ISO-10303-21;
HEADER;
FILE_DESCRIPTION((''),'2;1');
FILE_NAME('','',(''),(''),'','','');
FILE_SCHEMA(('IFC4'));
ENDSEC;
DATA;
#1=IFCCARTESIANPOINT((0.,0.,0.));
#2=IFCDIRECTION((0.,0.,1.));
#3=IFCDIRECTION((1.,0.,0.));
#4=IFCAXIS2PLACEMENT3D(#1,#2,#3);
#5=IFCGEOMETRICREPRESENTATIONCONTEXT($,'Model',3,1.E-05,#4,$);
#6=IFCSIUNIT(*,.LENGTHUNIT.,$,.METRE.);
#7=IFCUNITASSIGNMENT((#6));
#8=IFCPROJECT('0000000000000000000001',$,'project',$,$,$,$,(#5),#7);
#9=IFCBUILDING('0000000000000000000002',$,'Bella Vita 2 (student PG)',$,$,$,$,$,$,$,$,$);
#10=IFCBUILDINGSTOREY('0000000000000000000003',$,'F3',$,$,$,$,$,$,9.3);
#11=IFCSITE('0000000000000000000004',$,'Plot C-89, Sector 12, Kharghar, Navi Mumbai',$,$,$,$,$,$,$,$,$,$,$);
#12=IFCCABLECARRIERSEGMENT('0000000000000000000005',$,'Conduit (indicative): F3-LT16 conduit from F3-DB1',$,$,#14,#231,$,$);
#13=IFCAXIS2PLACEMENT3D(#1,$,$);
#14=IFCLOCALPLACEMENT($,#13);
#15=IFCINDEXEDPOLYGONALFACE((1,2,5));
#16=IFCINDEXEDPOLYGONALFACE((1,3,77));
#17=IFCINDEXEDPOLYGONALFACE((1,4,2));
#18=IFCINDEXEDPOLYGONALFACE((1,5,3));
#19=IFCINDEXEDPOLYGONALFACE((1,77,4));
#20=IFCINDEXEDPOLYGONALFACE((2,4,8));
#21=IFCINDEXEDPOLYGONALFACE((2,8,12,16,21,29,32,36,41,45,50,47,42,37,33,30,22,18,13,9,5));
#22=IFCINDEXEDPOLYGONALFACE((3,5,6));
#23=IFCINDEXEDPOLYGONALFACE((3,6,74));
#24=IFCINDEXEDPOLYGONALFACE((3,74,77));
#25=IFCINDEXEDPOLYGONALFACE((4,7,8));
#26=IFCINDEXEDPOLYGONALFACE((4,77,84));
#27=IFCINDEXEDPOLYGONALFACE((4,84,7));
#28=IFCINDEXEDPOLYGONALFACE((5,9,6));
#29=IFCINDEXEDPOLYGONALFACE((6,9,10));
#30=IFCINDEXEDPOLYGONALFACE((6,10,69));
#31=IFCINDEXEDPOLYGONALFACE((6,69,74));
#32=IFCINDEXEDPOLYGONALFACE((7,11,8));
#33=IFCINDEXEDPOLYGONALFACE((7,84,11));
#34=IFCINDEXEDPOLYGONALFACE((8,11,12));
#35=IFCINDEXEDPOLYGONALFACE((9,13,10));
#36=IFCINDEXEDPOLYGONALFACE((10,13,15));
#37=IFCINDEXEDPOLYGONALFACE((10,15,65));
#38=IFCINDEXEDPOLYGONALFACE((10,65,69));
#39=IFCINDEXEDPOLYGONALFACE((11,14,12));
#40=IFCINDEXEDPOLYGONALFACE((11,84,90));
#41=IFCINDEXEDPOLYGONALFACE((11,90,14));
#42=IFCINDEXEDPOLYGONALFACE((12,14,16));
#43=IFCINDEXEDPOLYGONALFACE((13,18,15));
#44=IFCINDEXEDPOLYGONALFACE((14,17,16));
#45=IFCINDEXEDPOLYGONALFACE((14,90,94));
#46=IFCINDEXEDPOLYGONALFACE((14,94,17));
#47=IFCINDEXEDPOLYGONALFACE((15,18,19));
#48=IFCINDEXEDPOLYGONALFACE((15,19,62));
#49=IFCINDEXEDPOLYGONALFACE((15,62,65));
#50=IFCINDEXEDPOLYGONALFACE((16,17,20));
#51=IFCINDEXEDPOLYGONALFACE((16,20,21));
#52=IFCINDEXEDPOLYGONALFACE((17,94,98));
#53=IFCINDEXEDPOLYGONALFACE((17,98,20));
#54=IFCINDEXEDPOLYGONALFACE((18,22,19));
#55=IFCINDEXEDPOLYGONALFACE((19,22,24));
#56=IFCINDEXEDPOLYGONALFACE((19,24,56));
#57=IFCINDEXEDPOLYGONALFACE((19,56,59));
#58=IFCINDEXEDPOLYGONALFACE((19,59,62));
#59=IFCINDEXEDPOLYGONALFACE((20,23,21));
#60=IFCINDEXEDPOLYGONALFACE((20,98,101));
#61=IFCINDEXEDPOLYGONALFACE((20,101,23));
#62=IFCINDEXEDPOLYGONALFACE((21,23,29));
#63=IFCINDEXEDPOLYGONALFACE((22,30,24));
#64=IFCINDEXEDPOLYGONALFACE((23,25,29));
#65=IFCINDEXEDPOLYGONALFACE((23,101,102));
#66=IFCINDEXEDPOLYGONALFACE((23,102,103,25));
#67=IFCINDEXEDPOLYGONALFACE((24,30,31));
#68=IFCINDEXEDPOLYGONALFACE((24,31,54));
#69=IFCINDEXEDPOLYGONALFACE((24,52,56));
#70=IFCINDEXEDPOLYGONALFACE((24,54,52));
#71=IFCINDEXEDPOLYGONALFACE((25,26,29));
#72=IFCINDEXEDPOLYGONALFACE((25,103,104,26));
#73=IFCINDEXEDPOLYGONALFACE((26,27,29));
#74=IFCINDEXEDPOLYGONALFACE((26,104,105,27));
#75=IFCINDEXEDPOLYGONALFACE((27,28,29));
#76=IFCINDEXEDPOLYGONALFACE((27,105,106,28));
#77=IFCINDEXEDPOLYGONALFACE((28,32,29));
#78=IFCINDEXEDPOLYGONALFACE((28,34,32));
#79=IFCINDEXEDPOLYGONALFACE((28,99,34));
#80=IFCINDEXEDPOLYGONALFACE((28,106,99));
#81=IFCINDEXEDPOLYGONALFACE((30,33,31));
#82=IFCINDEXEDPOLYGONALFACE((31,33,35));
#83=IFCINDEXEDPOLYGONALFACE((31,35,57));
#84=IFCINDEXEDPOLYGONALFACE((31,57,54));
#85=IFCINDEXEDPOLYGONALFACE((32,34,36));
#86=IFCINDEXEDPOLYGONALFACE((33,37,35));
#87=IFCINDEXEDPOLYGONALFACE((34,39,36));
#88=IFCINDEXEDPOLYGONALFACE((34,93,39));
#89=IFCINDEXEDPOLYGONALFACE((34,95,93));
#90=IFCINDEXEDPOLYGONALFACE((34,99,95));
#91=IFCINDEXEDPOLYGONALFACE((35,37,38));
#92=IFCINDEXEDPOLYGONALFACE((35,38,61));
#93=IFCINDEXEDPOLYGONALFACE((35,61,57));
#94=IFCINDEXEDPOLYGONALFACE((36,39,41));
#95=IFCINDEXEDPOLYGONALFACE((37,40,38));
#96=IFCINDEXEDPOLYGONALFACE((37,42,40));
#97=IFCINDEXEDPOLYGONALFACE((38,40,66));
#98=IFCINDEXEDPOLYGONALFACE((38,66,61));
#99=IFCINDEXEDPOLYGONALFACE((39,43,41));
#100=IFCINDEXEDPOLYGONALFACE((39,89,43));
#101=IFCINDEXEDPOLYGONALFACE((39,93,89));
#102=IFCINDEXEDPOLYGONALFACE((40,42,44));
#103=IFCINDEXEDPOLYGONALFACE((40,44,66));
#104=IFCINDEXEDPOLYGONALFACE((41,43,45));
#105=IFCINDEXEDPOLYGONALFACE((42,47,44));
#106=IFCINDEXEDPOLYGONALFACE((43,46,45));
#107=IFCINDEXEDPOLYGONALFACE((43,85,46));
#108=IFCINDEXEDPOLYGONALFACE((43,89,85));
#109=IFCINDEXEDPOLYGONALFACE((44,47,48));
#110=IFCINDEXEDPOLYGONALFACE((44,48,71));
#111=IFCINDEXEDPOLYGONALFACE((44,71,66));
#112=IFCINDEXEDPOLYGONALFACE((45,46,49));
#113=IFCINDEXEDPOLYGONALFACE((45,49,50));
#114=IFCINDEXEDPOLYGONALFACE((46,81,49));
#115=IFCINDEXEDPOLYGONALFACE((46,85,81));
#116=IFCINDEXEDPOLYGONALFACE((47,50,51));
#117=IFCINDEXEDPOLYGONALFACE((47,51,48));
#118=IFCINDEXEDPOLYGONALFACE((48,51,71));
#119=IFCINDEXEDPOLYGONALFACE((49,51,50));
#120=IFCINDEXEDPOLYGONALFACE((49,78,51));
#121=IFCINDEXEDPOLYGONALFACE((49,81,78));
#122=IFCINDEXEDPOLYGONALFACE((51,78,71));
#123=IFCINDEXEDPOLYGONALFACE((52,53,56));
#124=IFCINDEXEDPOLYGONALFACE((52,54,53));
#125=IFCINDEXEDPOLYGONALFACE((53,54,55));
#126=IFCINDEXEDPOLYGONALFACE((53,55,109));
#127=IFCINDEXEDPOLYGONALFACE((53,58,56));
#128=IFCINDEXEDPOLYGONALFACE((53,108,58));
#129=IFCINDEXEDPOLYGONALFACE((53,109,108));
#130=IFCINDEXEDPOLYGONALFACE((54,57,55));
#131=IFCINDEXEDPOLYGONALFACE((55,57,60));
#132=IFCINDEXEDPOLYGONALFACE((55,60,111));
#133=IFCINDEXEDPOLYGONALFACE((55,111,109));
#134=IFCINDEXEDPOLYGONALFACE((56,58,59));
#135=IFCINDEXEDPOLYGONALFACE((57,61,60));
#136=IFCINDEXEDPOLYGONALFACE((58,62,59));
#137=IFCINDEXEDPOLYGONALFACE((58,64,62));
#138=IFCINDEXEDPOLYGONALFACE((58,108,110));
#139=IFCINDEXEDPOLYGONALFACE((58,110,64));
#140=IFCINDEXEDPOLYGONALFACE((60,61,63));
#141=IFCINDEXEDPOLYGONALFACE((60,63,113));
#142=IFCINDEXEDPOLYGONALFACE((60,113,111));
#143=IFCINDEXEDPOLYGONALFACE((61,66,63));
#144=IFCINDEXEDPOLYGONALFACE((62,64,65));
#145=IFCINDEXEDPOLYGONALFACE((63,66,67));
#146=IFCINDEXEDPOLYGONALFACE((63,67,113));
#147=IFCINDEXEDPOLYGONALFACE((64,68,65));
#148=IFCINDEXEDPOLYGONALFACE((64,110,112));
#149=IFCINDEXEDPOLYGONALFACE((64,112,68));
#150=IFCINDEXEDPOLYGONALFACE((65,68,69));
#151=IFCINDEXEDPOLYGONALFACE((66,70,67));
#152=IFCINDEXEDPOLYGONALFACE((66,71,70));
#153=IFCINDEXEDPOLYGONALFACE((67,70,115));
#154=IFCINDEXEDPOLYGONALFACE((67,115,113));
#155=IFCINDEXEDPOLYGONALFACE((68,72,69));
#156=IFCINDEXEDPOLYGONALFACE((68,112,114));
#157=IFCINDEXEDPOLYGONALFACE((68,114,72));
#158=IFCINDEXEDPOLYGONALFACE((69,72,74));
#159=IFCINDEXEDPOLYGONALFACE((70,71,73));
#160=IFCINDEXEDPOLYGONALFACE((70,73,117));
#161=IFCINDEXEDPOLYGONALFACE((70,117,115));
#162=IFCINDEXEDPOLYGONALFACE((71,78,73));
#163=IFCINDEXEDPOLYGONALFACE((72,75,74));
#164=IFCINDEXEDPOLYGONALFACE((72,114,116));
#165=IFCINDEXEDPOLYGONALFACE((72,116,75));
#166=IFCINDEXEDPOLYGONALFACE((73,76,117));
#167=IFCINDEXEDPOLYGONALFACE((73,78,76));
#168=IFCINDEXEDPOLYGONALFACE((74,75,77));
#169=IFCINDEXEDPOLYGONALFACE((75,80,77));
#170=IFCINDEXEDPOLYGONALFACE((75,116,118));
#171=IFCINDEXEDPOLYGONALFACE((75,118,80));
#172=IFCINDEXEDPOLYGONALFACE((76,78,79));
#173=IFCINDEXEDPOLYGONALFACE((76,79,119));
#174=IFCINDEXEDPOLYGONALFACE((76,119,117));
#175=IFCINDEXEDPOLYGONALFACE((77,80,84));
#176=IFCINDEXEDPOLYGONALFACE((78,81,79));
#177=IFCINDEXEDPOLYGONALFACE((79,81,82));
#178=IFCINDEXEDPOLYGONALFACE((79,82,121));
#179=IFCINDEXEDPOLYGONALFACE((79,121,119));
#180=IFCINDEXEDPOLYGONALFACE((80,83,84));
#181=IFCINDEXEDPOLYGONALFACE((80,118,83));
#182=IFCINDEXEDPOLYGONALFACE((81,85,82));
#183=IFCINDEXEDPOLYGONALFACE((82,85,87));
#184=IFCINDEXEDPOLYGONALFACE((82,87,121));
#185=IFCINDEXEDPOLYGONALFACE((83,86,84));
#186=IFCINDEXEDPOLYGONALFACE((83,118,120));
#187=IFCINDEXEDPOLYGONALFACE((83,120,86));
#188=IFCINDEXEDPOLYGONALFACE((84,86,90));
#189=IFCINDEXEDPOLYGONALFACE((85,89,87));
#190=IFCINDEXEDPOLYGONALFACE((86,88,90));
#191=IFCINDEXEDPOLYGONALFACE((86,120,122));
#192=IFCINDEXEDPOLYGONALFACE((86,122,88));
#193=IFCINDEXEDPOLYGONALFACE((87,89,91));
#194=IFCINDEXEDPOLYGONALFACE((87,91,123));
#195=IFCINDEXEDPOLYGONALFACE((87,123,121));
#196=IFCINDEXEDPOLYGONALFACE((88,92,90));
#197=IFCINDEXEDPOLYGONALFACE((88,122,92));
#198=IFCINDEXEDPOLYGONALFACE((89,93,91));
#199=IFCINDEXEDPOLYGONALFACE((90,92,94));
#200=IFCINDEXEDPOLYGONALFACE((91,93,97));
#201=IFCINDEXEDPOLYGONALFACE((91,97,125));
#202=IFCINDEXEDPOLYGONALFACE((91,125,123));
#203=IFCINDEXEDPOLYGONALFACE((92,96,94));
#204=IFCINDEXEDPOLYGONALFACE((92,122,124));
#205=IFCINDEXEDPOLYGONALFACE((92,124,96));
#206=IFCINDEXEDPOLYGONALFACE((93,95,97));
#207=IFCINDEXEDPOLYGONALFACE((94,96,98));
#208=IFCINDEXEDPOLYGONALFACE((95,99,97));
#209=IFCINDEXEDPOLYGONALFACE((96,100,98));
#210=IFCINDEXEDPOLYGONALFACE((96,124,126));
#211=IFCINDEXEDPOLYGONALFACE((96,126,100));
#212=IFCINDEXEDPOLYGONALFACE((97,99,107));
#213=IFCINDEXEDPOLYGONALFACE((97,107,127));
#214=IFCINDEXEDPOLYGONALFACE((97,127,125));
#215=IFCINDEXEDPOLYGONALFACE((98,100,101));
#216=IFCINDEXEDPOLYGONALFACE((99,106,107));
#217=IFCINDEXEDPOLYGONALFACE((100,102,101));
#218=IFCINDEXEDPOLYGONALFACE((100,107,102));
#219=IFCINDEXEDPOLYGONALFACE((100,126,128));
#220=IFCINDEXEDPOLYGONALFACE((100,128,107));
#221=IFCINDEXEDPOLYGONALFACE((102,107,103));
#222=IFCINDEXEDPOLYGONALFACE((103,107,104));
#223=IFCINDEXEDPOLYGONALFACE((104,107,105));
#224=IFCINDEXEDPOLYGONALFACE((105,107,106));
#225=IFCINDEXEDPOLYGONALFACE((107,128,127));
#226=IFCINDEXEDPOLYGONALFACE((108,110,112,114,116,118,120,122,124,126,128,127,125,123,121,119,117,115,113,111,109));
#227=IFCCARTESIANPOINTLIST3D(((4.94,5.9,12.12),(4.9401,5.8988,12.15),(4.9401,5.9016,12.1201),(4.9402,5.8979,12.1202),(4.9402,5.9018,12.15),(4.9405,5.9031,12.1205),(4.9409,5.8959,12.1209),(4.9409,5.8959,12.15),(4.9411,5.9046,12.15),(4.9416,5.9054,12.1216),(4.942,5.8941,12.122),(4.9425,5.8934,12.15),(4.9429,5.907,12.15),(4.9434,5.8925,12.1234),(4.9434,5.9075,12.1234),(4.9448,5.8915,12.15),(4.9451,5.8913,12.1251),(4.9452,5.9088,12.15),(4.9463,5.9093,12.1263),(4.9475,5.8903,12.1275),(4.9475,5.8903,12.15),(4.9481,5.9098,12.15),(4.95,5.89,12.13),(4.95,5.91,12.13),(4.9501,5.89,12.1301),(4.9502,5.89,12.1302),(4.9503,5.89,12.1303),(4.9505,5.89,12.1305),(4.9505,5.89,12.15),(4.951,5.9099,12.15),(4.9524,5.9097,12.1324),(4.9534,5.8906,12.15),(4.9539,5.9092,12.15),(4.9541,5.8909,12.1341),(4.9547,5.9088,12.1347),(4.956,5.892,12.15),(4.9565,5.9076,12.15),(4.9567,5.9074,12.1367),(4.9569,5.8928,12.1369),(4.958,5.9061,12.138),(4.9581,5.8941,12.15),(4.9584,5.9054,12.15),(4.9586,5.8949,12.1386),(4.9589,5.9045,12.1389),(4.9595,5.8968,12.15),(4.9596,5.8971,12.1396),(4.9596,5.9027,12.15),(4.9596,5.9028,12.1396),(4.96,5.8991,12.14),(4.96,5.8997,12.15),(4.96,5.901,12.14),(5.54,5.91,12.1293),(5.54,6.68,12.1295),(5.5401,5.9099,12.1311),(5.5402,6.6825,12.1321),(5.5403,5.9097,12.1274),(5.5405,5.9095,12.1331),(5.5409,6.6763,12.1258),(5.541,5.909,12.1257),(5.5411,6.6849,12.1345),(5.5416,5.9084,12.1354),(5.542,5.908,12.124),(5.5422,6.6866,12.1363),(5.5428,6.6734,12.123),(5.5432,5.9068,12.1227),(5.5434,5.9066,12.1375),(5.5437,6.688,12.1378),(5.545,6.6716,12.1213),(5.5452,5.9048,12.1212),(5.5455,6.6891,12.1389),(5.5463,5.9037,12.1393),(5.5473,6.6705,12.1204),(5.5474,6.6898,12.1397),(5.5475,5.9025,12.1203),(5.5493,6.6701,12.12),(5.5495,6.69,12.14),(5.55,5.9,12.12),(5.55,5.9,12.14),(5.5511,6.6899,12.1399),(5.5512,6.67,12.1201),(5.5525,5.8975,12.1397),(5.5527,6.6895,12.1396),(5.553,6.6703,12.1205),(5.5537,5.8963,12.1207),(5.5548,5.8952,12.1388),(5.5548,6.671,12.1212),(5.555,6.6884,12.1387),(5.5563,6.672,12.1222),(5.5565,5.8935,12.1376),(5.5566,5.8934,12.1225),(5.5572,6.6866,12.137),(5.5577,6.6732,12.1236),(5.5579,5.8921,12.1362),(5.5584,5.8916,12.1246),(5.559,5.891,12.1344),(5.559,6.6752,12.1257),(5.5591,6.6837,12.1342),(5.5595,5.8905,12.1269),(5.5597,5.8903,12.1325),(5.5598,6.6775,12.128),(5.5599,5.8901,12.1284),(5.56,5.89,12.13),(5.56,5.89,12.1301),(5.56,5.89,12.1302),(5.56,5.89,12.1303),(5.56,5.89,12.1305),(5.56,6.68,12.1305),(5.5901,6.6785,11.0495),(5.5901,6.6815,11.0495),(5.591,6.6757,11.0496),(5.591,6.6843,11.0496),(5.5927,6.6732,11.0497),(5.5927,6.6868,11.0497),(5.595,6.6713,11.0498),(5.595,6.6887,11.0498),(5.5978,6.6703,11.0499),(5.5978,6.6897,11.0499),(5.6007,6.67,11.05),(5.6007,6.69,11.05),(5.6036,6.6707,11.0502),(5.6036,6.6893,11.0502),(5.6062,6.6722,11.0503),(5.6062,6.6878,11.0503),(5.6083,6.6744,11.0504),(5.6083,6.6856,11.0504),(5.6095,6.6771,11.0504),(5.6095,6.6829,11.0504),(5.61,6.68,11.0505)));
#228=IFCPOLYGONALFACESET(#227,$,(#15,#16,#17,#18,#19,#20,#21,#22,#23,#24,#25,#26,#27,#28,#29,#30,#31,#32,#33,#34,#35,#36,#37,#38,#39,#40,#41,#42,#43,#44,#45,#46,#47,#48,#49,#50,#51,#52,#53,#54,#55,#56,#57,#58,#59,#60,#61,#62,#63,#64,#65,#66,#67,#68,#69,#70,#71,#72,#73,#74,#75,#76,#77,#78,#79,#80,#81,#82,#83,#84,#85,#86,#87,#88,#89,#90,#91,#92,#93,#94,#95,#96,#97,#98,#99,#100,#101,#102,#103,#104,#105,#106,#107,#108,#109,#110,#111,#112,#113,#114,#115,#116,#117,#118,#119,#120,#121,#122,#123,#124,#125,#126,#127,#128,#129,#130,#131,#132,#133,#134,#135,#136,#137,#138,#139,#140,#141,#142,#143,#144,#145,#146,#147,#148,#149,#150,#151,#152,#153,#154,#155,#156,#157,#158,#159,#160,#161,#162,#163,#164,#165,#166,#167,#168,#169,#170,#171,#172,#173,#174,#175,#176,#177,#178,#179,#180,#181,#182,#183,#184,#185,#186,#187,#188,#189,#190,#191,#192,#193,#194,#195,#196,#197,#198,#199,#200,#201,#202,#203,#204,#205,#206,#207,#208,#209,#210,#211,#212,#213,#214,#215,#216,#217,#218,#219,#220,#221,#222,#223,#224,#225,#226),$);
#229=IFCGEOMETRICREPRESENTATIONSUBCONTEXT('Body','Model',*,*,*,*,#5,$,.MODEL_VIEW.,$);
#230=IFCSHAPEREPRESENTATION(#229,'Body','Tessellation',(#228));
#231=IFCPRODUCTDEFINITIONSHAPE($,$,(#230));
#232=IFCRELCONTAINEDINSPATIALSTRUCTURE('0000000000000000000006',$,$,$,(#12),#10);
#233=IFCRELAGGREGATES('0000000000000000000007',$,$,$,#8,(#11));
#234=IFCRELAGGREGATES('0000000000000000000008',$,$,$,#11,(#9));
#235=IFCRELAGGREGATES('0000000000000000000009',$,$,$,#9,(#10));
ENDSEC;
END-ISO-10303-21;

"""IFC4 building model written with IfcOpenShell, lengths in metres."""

from ifc_helpers import new_model, entity, si_unit, origin, origin_with_axes, place, context, subcontext, project, spatial, element, save


model = new_model("IFC4")

# Units and contexts
model_context = context("Model", 3, precision=1e-05, world=origin_with_axes())
body_context = subcontext(model_context, "Body", "Model", "MODEL_VIEW")
ifc_project = project(units=[si_unit("LENGTHUNIT", "METRE")], contexts=[model_context])

# Site, building, storey
site = spatial("IfcSite", under=ifc_project, Name="Plot C-89, Sector 12, Kharghar, Navi Mumbai")
building = spatial("IfcBuilding", under=site, Name="Bella Vita 2 (student PG)")
storey = spatial("IfcBuildingStorey", under=building, Name="F3", Elevation=9.3)

# Cable carrier segment
cable_carrier_segment_1_placement = place(None, origin())
element("IfcCableCarrierSegment", 1, at=cable_carrier_segment_1_placement, inside=storey, Name="Conduit (indicative): F3-LT16 conduit from F3-DB1", context=body_context, shape_type="AdvancedSweptSolid", body=[
    entity("IfcSweptDiskSolid", entity("IfcPolyline", [entity("IfcCartesianPoint", [5.6, 6.68, 11.05]), entity("IfcCartesianPoint", [5.55, 6.68, 12.13]), entity("IfcCartesianPoint", [5.55, 5.9, 12.13]), entity("IfcCartesianPoint", [4.95, 5.9, 12.13]), entity("IfcCartesianPoint", [4.95, 5.9, 12.15])]), 0.01),
])

save(model, "model.ifc")
